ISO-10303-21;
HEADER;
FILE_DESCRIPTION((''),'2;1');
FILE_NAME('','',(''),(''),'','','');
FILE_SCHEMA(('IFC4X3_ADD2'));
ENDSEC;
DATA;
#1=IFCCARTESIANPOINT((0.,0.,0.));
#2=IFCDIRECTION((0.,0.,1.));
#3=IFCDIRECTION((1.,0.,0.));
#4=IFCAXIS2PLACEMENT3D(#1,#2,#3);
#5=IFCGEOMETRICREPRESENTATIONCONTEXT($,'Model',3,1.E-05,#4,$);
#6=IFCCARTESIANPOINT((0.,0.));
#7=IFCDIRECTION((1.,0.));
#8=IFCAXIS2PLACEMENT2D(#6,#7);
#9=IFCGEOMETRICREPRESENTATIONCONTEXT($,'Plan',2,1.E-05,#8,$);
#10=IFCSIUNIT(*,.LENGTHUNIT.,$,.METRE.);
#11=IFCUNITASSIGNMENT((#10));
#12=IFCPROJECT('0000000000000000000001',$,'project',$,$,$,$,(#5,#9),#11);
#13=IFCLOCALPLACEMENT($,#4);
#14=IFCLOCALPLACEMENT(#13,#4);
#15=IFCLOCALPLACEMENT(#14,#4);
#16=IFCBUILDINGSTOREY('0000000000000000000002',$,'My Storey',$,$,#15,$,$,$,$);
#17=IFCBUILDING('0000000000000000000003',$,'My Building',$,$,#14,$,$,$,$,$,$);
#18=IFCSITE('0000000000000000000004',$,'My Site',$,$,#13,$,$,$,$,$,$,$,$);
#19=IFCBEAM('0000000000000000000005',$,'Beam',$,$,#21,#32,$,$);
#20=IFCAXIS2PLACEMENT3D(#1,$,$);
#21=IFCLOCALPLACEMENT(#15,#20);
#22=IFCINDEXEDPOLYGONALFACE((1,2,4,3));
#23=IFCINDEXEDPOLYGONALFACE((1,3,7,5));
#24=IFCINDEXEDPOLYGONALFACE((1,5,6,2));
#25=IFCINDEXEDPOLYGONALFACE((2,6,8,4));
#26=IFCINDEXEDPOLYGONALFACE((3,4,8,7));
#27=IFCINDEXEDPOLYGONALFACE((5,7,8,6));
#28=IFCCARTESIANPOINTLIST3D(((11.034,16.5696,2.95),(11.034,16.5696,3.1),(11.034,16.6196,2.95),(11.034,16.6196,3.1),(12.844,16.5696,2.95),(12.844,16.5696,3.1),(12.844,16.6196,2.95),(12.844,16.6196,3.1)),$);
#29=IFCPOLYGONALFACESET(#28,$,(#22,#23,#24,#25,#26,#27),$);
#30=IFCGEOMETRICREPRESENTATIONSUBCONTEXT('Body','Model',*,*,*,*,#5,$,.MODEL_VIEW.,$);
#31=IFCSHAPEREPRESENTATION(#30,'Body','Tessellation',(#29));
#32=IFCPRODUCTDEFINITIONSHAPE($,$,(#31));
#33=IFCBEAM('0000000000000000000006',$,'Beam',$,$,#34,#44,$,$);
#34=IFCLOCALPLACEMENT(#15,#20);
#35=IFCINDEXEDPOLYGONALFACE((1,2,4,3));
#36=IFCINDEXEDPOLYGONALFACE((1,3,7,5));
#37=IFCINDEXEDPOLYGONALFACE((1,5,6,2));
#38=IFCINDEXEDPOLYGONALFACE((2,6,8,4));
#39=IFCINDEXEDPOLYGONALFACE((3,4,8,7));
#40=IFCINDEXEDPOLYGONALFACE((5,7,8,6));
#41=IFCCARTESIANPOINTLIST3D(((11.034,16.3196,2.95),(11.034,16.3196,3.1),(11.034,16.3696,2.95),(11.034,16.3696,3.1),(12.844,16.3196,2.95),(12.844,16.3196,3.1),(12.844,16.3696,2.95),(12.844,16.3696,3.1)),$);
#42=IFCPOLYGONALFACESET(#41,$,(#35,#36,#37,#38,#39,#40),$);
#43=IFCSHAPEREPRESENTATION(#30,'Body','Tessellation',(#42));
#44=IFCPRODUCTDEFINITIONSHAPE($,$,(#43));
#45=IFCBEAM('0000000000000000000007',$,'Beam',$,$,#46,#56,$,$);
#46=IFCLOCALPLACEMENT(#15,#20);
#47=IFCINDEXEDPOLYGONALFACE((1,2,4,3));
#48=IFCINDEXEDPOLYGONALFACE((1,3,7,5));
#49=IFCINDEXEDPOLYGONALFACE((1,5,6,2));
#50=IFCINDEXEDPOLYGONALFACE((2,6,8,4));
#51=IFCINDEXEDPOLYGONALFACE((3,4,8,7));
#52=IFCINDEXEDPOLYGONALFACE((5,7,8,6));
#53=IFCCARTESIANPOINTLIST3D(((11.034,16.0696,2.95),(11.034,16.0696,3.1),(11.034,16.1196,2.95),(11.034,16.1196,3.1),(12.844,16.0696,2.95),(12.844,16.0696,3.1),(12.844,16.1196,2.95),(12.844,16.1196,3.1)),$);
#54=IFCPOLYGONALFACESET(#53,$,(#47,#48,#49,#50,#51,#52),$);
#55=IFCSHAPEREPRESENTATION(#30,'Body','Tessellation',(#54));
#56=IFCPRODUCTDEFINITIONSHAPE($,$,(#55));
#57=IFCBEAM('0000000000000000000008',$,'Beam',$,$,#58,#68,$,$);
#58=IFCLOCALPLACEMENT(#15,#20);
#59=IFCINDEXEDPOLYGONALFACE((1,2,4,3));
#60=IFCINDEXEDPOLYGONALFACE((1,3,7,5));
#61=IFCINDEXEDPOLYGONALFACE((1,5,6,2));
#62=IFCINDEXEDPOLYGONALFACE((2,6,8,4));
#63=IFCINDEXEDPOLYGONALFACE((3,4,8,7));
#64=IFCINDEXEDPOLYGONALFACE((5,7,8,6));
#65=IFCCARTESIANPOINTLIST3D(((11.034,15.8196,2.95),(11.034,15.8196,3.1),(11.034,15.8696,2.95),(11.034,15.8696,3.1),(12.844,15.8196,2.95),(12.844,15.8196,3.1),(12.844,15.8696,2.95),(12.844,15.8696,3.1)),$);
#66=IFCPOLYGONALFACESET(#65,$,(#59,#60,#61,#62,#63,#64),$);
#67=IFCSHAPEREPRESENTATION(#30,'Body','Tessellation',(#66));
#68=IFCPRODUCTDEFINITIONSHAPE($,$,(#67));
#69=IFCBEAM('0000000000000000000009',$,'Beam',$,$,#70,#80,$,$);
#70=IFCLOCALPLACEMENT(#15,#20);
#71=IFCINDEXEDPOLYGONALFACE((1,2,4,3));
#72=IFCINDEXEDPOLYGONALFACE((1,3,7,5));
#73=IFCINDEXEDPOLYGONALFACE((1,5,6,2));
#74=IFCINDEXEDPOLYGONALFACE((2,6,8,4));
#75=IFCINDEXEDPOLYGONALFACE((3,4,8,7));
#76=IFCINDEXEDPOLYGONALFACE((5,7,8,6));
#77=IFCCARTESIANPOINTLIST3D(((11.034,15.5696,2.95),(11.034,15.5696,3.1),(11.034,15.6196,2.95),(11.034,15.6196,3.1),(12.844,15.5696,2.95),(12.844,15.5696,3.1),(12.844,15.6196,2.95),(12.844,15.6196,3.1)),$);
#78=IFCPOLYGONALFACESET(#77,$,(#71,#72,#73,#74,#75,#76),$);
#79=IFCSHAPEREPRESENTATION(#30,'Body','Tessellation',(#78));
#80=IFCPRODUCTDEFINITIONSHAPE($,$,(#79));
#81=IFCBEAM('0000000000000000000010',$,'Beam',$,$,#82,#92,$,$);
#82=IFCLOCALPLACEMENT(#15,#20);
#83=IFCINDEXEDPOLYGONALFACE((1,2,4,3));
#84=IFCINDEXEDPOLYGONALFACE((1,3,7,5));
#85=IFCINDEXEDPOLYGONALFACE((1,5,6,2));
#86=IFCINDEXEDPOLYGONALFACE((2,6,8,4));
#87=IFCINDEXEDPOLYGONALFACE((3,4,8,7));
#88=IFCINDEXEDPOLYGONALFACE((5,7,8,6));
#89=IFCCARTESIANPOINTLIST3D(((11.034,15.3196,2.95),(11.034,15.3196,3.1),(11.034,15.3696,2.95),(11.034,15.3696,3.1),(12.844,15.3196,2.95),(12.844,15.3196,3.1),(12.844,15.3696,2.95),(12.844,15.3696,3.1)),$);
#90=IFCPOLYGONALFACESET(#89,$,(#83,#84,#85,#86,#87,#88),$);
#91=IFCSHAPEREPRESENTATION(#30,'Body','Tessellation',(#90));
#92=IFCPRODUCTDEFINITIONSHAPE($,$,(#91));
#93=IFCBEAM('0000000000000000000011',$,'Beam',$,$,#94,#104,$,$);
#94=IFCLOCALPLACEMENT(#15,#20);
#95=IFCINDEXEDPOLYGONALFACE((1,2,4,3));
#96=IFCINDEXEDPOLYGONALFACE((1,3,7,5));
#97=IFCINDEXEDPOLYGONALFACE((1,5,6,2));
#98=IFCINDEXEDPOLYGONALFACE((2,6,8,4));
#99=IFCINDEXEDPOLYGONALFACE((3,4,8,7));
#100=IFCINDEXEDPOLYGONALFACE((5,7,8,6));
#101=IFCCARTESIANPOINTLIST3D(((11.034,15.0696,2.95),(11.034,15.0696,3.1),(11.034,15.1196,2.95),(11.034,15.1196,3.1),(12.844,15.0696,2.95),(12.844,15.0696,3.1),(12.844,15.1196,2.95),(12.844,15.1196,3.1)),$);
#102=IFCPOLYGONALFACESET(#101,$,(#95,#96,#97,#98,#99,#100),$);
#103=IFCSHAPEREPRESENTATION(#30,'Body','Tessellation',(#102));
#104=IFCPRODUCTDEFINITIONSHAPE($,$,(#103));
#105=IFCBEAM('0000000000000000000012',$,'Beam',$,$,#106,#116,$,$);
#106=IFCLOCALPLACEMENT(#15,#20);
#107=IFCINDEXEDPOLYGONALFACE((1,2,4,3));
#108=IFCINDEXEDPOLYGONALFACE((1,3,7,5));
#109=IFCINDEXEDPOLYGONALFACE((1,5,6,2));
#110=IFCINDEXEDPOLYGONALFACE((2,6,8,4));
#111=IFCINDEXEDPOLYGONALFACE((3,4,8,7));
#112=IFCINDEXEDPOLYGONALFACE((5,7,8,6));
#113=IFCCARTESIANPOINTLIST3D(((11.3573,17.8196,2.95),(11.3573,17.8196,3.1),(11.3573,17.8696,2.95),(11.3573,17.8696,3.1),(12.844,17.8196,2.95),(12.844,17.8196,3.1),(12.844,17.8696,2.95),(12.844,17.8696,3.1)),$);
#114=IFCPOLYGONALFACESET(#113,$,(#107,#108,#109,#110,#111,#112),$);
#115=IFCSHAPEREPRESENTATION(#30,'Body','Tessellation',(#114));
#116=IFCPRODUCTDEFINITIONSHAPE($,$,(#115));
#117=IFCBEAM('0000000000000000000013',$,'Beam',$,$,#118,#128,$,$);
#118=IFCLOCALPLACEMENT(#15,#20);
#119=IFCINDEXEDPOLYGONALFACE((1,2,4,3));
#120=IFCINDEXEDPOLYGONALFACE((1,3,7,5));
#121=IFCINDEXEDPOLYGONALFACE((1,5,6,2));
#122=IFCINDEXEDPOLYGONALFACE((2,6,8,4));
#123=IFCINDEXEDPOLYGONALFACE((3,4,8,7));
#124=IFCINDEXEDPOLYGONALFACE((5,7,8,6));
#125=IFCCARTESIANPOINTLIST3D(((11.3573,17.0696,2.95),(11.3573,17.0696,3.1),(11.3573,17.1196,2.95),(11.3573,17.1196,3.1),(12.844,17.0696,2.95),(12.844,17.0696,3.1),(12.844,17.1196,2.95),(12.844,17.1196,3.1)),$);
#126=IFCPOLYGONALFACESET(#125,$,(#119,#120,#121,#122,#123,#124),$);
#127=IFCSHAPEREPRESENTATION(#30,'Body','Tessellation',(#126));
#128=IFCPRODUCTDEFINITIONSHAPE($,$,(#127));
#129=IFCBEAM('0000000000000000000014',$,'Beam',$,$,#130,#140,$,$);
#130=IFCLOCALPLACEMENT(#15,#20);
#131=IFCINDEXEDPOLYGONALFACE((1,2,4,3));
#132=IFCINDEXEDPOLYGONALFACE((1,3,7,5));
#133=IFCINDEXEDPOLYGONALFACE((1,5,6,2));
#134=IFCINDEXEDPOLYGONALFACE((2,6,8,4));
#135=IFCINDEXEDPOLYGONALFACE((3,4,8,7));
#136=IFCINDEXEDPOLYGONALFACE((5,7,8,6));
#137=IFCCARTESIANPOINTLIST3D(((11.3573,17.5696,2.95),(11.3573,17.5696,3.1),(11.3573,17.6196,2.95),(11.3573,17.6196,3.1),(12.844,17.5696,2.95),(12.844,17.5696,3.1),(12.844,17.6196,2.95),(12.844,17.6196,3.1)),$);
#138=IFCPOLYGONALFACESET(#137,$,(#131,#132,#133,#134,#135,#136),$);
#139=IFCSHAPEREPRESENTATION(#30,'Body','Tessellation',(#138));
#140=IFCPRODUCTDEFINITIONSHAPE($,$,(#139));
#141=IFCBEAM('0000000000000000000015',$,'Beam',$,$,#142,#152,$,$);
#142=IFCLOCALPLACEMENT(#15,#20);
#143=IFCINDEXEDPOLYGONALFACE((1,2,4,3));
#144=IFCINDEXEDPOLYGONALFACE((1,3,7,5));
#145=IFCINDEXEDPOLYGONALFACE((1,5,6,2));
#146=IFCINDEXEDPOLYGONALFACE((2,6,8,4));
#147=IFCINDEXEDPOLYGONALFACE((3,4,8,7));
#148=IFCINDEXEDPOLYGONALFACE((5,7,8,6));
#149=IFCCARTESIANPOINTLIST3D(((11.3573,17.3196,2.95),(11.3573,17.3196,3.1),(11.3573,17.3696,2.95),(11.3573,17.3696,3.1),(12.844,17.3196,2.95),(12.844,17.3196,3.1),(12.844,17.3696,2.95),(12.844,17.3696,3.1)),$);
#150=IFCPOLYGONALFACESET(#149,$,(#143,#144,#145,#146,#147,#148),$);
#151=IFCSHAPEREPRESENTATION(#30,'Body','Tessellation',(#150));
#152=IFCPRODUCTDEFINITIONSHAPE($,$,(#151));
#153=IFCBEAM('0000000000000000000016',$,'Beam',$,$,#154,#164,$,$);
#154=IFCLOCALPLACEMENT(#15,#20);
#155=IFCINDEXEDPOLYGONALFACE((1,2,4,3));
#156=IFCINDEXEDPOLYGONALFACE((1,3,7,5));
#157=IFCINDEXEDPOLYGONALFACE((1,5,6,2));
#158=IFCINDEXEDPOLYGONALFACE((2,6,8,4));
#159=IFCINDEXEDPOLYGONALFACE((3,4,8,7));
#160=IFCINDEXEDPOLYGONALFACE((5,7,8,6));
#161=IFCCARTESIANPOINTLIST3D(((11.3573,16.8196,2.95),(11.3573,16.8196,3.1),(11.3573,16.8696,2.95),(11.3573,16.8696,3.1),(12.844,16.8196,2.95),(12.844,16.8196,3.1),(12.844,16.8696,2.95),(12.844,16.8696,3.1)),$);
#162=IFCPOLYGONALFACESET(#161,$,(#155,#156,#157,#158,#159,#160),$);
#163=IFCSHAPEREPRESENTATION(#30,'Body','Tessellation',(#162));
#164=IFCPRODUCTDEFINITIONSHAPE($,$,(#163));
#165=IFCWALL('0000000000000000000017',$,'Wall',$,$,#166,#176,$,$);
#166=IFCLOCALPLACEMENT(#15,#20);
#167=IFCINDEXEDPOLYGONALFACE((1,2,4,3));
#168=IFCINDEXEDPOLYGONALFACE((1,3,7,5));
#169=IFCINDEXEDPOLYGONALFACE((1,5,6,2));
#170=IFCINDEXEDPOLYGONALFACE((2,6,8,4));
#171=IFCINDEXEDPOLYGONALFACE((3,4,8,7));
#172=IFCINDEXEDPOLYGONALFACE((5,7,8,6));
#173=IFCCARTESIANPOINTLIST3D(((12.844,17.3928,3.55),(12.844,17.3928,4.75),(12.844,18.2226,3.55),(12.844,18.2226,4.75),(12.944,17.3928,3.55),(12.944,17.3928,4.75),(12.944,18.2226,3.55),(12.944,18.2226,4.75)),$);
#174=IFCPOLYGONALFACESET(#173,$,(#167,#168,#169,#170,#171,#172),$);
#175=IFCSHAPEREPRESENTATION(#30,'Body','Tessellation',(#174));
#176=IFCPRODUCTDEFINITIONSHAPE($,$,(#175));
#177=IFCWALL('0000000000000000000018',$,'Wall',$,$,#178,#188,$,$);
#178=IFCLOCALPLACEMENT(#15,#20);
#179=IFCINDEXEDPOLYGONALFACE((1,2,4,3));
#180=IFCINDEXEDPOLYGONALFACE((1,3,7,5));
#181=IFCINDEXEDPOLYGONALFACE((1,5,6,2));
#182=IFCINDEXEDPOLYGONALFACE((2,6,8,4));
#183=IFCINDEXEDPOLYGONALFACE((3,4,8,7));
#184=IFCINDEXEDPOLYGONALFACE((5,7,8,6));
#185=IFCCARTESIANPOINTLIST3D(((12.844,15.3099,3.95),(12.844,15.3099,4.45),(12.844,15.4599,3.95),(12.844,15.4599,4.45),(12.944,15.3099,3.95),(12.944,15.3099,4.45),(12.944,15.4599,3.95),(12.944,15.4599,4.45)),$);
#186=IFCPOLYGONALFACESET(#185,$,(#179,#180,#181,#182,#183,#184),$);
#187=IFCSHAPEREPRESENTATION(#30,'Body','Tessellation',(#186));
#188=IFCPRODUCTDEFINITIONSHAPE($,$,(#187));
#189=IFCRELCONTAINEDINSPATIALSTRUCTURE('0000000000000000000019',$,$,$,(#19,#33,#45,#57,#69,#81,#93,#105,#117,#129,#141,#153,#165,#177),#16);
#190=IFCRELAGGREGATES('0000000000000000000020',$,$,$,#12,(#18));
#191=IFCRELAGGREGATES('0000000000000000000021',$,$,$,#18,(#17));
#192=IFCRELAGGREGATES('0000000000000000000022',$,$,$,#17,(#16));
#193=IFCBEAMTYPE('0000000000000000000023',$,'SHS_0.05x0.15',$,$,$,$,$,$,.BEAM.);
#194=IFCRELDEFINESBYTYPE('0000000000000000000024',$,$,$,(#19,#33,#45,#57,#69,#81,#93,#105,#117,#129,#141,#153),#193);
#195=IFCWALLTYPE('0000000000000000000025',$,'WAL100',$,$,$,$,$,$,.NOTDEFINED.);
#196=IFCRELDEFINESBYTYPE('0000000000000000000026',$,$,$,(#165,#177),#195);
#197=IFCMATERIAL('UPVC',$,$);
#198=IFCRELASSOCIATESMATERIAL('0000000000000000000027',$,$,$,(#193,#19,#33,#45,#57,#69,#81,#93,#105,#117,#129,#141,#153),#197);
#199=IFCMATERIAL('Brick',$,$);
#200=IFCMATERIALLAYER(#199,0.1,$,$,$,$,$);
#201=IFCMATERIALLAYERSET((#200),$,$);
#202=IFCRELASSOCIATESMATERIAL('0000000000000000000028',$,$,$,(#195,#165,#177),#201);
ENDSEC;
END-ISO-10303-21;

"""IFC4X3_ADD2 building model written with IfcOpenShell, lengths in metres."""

from ifc_helpers import new_model, si_unit, frame, origin_with_axes, origin_2d_with_axis, place, context, subcontext, project, spatial, line, indexed_curve, outline, extrude, material, layer, layer_set, layer_usage, material_profile, profile_set, profile_usage, type_object, element, save


model = new_model("IFC4X3_ADD2")

# Units and contexts
model_context = context("Model", 3, precision=1e-05, world=origin_with_axes())
plan_context = context("Plan", 2, precision=1e-05, world=origin_2d_with_axis())
body_context = subcontext(model_context, "Body", "Model", "MODEL_VIEW")
ifc_project = project(units=[si_unit("LENGTHUNIT", "METRE")], contexts=[model_context, plan_context])

# Site, building, storey
site_placement = place(None, origin_with_axes())
site = spatial("IfcSite", under=ifc_project, at=site_placement, Name="My Site")
building_placement = place(site_placement, origin_with_axes())
building = spatial("IfcBuilding", under=site, at=building_placement, Name="My Building")
storey_placement = place(building_placement, origin_with_axes())
storey = spatial("IfcBuildingStorey", under=building, at=storey_placement, Name="My Storey")

# Beams
ifc_material_1 = material(Name="UPVC")
ifc_material_profile = material_profile(ifc_material_1, outline(indexed_curve([(-0.025, 0.075), (0.025, 0.075), (0.025, -0.075), (-0.025, -0.075), (-0.025, 0.075)])))
ifc_profile_set = profile_set([ifc_material_profile])
ifc_profile_usage_1 = profile_usage(ifc_profile_set, cardinal=5)
beam_type = type_object("IfcBeamType", Name="SHS_0.05x0.15", PredefinedType="BEAM", material=ifc_profile_set)
beam_1_placement = place(storey_placement, frame((12.844, 16.5946, 3.025), z_axis=(-1.0, 0.0, 0.0), x_axis=(0.0, -1.0, 0.0)))
element("IfcBeam", 1, at=beam_1_placement, inside=storey, type_object=beam_type, material=ifc_profile_usage_1, Name="Beam", context=body_context, shape_type="SweptSolid", body=[
    extrude(outline(indexed_curve([(-0.025, 0.075), (0.025, 0.075), (0.025, -0.075), (-0.025, -0.075), (-0.025, 0.075)])), origin_with_axes(), (0.0, 0.0, 1.0), 1.81),
])
ifc_profile_usage_2 = profile_usage(ifc_profile_set, cardinal=5)
beam_2_placement = place(storey_placement, frame((12.844, 16.3446, 3.025), z_axis=(-1.0, 0.0, 0.0), x_axis=(0.0, -1.0, 0.0)))
element("IfcBeam", 2, at=beam_2_placement, inside=storey, type_object=beam_type, material=ifc_profile_usage_2, Name="Beam", context=body_context, shape_type="SweptSolid", body=[
    extrude(outline(indexed_curve([(-0.025, 0.075), (0.025, 0.075), (0.025, -0.075), (-0.025, -0.075), (-0.025, 0.075)])), origin_with_axes(), (0.0, 0.0, 1.0), 1.81),
])
ifc_profile_usage_3 = profile_usage(ifc_profile_set, cardinal=5)
beam_3_placement = place(storey_placement, frame((12.844, 16.0946, 3.025), z_axis=(-1.0, 0.0, 0.0), x_axis=(0.0, -1.0, 0.0)))
element("IfcBeam", 3, at=beam_3_placement, inside=storey, type_object=beam_type, material=ifc_profile_usage_3, Name="Beam", context=body_context, shape_type="SweptSolid", body=[
    extrude(outline(indexed_curve([(-0.025, 0.075), (0.025, 0.075), (0.025, -0.075), (-0.025, -0.075), (-0.025, 0.075)])), origin_with_axes(), (0.0, 0.0, 1.0), 1.81),
])
ifc_profile_usage_4 = profile_usage(ifc_profile_set, cardinal=5)
beam_4_placement = place(storey_placement, frame((12.844, 15.8446, 3.025), z_axis=(-1.0, 0.0, 0.0), x_axis=(0.0, -1.0, 0.0)))
element("IfcBeam", 4, at=beam_4_placement, inside=storey, type_object=beam_type, material=ifc_profile_usage_4, Name="Beam", context=body_context, shape_type="SweptSolid", body=[
    extrude(outline(indexed_curve([(-0.025, 0.075), (0.025, 0.075), (0.025, -0.075), (-0.025, -0.075), (-0.025, 0.075)])), origin_with_axes(), (0.0, 0.0, 1.0), 1.81),
])
ifc_profile_usage_5 = profile_usage(ifc_profile_set, cardinal=5)
beam_5_placement = place(storey_placement, frame((12.844, 15.5946, 3.025), z_axis=(-1.0, 0.0, 0.0), x_axis=(0.0, -1.0, 0.0)))
element("IfcBeam", 5, at=beam_5_placement, inside=storey, type_object=beam_type, material=ifc_profile_usage_5, Name="Beam", context=body_context, shape_type="SweptSolid", body=[
    extrude(outline(indexed_curve([(-0.025, 0.075), (0.025, 0.075), (0.025, -0.075), (-0.025, -0.075), (-0.025, 0.075)])), origin_with_axes(), (0.0, 0.0, 1.0), 1.81),
])
ifc_profile_usage_6 = profile_usage(ifc_profile_set, cardinal=5)
beam_6_placement = place(storey_placement, frame((12.844, 15.3446, 3.025), z_axis=(-1.0, 0.0, 0.0), x_axis=(0.0, -1.0, 0.0)))
element("IfcBeam", 6, at=beam_6_placement, inside=storey, type_object=beam_type, material=ifc_profile_usage_6, Name="Beam", context=body_context, shape_type="SweptSolid", body=[
    extrude(outline(indexed_curve([(-0.025, 0.075), (0.025, 0.075), (0.025, -0.075), (-0.025, -0.075), (-0.025, 0.075)])), origin_with_axes(), (0.0, 0.0, 1.0), 1.81),
])
ifc_profile_usage_7 = profile_usage(ifc_profile_set, cardinal=5)
beam_7_placement = place(storey_placement, frame((12.844, 15.0946, 3.025), z_axis=(-1.0, 0.0, 0.0), x_axis=(0.0, -1.0, 0.0)))
element("IfcBeam", 7, at=beam_7_placement, inside=storey, type_object=beam_type, material=ifc_profile_usage_7, Name="Beam", context=body_context, shape_type="SweptSolid", body=[
    extrude(outline(indexed_curve([(-0.025, 0.075), (0.025, 0.075), (0.025, -0.075), (-0.025, -0.075), (-0.025, 0.075)])), origin_with_axes(), (0.0, 0.0, 1.0), 1.81),
])
ifc_profile_usage_8 = profile_usage(ifc_profile_set, cardinal=5)
beam_8_placement = place(storey_placement, frame((12.844, 17.8446, 3.025), z_axis=(-1.0, 0.0, 0.0), x_axis=(0.0, -1.0, 0.0)))
element("IfcBeam", 8, at=beam_8_placement, inside=storey, type_object=beam_type, material=ifc_profile_usage_8, Name="Beam", context=body_context, shape_type="SweptSolid", body=[
    extrude(outline(indexed_curve([(-0.025, 0.075), (0.025, 0.075), (0.025, -0.075), (-0.025, -0.075), (-0.025, 0.075)])), origin_with_axes(), (0.0, 0.0, 1.0), 1.4867),
])
ifc_profile_usage_9 = profile_usage(ifc_profile_set, cardinal=5)
beam_9_placement = place(storey_placement, frame((12.844, 17.0946, 3.025), z_axis=(-1.0, 0.0, 0.0), x_axis=(0.0, -1.0, 0.0)))
element("IfcBeam", 9, at=beam_9_placement, inside=storey, type_object=beam_type, material=ifc_profile_usage_9, Name="Beam", context=body_context, shape_type="SweptSolid", body=[
    extrude(outline(indexed_curve([(-0.025, 0.075), (0.025, 0.075), (0.025, -0.075), (-0.025, -0.075), (-0.025, 0.075)])), origin_with_axes(), (0.0, 0.0, 1.0), 1.4867),
])
ifc_profile_usage_10 = profile_usage(ifc_profile_set, cardinal=5)
beam_10_placement = place(storey_placement, frame((12.844, 17.5946, 3.025), z_axis=(-1.0, 0.0, 0.0), x_axis=(0.0, -1.0, 0.0)))
element("IfcBeam", 10, at=beam_10_placement, inside=storey, type_object=beam_type, material=ifc_profile_usage_10, Name="Beam", context=body_context, shape_type="SweptSolid", body=[
    extrude(outline(indexed_curve([(-0.025, 0.075), (0.025, 0.075), (0.025, -0.075), (-0.025, -0.075), (-0.025, 0.075)])), origin_with_axes(), (0.0, 0.0, 1.0), 1.4867),
])
ifc_profile_usage_11 = profile_usage(ifc_profile_set, cardinal=5)
beam_11_placement = place(storey_placement, frame((12.844, 17.3446, 3.025), z_axis=(-1.0, 0.0, 0.0), x_axis=(0.0, -1.0, 0.0)))
element("IfcBeam", 11, at=beam_11_placement, inside=storey, type_object=beam_type, material=ifc_profile_usage_11, Name="Beam", context=body_context, shape_type="SweptSolid", body=[
    extrude(outline(indexed_curve([(-0.025, 0.075), (0.025, 0.075), (0.025, -0.075), (-0.025, -0.075), (-0.025, 0.075)])), origin_with_axes(), (0.0, 0.0, 1.0), 1.4867),
])
ifc_profile_usage_12 = profile_usage(ifc_profile_set, cardinal=5)
beam_12_placement = place(storey_placement, frame((12.844, 16.8446, 3.025), z_axis=(-1.0, 0.0, 0.0), x_axis=(0.0, -1.0, 0.0)))
element("IfcBeam", 12, at=beam_12_placement, inside=storey, type_object=beam_type, material=ifc_profile_usage_12, Name="Beam", context=body_context, shape_type="SweptSolid", body=[
    extrude(outline(indexed_curve([(-0.025, 0.075), (0.025, 0.075), (0.025, -0.075), (-0.025, -0.075), (-0.025, 0.075)])), origin_with_axes(), (0.0, 0.0, 1.0), 1.4867),
])

# Walls
ifc_material_2 = material(Name="Brick")
ifc_layer = layer(ifc_material_2, 0.1)
ifc_layer_set = layer_set([ifc_layer])
ifc_layer_usage_1 = layer_usage(ifc_layer_set, "AXIS2", "POSITIVE", 0.0)
wall_type = type_object("IfcWallType", Name="WAL100", PredefinedType="NOTDEFINED", material=ifc_layer_set)
wall_1_placement = place(storey_placement, frame((12.944, 17.3928, 3.55), z_axis=(0.0, 0.0, 1.0), x_axis=(-0.000005, 1.0, 0.0)))
element("IfcWall", 13, at=wall_1_placement, inside=storey, type_object=wall_type, material=ifc_layer_usage_1, Name="Wall", context=body_context, shape_type="SweptSolid", body=[
    extrude(outline(indexed_curve([(0.0, 0.0), (0.0, 0.1), (0.8298, 0.1), (0.8298, 0.0)], segments=[line(1, 2, 3, 4, 1)])), origin_with_axes(), (0.0, 0.0, 1.0), 1.2),
])
ifc_layer_usage_2 = layer_usage(ifc_layer_set, "AXIS2", "POSITIVE", 0.0)
wall_2_placement = place(storey_placement, frame((12.944, 15.3099, 3.95), z_axis=(0.0, 0.0, 1.0), x_axis=(-0.000005, 1.0, 0.0)))
element("IfcWall", 14, at=wall_2_placement, inside=storey, type_object=wall_type, material=ifc_layer_usage_2, Name="Wall", context=body_context, shape_type="SweptSolid", body=[
    extrude(outline(indexed_curve([(0.0, 0.0), (0.0, 0.1), (0.15, 0.1), (0.15, 0.0)], segments=[line(1, 2, 3, 4, 1)])), origin_with_axes(), (0.0, 0.0, 1.0), 0.5),
])

save(model, "model.ifc")
